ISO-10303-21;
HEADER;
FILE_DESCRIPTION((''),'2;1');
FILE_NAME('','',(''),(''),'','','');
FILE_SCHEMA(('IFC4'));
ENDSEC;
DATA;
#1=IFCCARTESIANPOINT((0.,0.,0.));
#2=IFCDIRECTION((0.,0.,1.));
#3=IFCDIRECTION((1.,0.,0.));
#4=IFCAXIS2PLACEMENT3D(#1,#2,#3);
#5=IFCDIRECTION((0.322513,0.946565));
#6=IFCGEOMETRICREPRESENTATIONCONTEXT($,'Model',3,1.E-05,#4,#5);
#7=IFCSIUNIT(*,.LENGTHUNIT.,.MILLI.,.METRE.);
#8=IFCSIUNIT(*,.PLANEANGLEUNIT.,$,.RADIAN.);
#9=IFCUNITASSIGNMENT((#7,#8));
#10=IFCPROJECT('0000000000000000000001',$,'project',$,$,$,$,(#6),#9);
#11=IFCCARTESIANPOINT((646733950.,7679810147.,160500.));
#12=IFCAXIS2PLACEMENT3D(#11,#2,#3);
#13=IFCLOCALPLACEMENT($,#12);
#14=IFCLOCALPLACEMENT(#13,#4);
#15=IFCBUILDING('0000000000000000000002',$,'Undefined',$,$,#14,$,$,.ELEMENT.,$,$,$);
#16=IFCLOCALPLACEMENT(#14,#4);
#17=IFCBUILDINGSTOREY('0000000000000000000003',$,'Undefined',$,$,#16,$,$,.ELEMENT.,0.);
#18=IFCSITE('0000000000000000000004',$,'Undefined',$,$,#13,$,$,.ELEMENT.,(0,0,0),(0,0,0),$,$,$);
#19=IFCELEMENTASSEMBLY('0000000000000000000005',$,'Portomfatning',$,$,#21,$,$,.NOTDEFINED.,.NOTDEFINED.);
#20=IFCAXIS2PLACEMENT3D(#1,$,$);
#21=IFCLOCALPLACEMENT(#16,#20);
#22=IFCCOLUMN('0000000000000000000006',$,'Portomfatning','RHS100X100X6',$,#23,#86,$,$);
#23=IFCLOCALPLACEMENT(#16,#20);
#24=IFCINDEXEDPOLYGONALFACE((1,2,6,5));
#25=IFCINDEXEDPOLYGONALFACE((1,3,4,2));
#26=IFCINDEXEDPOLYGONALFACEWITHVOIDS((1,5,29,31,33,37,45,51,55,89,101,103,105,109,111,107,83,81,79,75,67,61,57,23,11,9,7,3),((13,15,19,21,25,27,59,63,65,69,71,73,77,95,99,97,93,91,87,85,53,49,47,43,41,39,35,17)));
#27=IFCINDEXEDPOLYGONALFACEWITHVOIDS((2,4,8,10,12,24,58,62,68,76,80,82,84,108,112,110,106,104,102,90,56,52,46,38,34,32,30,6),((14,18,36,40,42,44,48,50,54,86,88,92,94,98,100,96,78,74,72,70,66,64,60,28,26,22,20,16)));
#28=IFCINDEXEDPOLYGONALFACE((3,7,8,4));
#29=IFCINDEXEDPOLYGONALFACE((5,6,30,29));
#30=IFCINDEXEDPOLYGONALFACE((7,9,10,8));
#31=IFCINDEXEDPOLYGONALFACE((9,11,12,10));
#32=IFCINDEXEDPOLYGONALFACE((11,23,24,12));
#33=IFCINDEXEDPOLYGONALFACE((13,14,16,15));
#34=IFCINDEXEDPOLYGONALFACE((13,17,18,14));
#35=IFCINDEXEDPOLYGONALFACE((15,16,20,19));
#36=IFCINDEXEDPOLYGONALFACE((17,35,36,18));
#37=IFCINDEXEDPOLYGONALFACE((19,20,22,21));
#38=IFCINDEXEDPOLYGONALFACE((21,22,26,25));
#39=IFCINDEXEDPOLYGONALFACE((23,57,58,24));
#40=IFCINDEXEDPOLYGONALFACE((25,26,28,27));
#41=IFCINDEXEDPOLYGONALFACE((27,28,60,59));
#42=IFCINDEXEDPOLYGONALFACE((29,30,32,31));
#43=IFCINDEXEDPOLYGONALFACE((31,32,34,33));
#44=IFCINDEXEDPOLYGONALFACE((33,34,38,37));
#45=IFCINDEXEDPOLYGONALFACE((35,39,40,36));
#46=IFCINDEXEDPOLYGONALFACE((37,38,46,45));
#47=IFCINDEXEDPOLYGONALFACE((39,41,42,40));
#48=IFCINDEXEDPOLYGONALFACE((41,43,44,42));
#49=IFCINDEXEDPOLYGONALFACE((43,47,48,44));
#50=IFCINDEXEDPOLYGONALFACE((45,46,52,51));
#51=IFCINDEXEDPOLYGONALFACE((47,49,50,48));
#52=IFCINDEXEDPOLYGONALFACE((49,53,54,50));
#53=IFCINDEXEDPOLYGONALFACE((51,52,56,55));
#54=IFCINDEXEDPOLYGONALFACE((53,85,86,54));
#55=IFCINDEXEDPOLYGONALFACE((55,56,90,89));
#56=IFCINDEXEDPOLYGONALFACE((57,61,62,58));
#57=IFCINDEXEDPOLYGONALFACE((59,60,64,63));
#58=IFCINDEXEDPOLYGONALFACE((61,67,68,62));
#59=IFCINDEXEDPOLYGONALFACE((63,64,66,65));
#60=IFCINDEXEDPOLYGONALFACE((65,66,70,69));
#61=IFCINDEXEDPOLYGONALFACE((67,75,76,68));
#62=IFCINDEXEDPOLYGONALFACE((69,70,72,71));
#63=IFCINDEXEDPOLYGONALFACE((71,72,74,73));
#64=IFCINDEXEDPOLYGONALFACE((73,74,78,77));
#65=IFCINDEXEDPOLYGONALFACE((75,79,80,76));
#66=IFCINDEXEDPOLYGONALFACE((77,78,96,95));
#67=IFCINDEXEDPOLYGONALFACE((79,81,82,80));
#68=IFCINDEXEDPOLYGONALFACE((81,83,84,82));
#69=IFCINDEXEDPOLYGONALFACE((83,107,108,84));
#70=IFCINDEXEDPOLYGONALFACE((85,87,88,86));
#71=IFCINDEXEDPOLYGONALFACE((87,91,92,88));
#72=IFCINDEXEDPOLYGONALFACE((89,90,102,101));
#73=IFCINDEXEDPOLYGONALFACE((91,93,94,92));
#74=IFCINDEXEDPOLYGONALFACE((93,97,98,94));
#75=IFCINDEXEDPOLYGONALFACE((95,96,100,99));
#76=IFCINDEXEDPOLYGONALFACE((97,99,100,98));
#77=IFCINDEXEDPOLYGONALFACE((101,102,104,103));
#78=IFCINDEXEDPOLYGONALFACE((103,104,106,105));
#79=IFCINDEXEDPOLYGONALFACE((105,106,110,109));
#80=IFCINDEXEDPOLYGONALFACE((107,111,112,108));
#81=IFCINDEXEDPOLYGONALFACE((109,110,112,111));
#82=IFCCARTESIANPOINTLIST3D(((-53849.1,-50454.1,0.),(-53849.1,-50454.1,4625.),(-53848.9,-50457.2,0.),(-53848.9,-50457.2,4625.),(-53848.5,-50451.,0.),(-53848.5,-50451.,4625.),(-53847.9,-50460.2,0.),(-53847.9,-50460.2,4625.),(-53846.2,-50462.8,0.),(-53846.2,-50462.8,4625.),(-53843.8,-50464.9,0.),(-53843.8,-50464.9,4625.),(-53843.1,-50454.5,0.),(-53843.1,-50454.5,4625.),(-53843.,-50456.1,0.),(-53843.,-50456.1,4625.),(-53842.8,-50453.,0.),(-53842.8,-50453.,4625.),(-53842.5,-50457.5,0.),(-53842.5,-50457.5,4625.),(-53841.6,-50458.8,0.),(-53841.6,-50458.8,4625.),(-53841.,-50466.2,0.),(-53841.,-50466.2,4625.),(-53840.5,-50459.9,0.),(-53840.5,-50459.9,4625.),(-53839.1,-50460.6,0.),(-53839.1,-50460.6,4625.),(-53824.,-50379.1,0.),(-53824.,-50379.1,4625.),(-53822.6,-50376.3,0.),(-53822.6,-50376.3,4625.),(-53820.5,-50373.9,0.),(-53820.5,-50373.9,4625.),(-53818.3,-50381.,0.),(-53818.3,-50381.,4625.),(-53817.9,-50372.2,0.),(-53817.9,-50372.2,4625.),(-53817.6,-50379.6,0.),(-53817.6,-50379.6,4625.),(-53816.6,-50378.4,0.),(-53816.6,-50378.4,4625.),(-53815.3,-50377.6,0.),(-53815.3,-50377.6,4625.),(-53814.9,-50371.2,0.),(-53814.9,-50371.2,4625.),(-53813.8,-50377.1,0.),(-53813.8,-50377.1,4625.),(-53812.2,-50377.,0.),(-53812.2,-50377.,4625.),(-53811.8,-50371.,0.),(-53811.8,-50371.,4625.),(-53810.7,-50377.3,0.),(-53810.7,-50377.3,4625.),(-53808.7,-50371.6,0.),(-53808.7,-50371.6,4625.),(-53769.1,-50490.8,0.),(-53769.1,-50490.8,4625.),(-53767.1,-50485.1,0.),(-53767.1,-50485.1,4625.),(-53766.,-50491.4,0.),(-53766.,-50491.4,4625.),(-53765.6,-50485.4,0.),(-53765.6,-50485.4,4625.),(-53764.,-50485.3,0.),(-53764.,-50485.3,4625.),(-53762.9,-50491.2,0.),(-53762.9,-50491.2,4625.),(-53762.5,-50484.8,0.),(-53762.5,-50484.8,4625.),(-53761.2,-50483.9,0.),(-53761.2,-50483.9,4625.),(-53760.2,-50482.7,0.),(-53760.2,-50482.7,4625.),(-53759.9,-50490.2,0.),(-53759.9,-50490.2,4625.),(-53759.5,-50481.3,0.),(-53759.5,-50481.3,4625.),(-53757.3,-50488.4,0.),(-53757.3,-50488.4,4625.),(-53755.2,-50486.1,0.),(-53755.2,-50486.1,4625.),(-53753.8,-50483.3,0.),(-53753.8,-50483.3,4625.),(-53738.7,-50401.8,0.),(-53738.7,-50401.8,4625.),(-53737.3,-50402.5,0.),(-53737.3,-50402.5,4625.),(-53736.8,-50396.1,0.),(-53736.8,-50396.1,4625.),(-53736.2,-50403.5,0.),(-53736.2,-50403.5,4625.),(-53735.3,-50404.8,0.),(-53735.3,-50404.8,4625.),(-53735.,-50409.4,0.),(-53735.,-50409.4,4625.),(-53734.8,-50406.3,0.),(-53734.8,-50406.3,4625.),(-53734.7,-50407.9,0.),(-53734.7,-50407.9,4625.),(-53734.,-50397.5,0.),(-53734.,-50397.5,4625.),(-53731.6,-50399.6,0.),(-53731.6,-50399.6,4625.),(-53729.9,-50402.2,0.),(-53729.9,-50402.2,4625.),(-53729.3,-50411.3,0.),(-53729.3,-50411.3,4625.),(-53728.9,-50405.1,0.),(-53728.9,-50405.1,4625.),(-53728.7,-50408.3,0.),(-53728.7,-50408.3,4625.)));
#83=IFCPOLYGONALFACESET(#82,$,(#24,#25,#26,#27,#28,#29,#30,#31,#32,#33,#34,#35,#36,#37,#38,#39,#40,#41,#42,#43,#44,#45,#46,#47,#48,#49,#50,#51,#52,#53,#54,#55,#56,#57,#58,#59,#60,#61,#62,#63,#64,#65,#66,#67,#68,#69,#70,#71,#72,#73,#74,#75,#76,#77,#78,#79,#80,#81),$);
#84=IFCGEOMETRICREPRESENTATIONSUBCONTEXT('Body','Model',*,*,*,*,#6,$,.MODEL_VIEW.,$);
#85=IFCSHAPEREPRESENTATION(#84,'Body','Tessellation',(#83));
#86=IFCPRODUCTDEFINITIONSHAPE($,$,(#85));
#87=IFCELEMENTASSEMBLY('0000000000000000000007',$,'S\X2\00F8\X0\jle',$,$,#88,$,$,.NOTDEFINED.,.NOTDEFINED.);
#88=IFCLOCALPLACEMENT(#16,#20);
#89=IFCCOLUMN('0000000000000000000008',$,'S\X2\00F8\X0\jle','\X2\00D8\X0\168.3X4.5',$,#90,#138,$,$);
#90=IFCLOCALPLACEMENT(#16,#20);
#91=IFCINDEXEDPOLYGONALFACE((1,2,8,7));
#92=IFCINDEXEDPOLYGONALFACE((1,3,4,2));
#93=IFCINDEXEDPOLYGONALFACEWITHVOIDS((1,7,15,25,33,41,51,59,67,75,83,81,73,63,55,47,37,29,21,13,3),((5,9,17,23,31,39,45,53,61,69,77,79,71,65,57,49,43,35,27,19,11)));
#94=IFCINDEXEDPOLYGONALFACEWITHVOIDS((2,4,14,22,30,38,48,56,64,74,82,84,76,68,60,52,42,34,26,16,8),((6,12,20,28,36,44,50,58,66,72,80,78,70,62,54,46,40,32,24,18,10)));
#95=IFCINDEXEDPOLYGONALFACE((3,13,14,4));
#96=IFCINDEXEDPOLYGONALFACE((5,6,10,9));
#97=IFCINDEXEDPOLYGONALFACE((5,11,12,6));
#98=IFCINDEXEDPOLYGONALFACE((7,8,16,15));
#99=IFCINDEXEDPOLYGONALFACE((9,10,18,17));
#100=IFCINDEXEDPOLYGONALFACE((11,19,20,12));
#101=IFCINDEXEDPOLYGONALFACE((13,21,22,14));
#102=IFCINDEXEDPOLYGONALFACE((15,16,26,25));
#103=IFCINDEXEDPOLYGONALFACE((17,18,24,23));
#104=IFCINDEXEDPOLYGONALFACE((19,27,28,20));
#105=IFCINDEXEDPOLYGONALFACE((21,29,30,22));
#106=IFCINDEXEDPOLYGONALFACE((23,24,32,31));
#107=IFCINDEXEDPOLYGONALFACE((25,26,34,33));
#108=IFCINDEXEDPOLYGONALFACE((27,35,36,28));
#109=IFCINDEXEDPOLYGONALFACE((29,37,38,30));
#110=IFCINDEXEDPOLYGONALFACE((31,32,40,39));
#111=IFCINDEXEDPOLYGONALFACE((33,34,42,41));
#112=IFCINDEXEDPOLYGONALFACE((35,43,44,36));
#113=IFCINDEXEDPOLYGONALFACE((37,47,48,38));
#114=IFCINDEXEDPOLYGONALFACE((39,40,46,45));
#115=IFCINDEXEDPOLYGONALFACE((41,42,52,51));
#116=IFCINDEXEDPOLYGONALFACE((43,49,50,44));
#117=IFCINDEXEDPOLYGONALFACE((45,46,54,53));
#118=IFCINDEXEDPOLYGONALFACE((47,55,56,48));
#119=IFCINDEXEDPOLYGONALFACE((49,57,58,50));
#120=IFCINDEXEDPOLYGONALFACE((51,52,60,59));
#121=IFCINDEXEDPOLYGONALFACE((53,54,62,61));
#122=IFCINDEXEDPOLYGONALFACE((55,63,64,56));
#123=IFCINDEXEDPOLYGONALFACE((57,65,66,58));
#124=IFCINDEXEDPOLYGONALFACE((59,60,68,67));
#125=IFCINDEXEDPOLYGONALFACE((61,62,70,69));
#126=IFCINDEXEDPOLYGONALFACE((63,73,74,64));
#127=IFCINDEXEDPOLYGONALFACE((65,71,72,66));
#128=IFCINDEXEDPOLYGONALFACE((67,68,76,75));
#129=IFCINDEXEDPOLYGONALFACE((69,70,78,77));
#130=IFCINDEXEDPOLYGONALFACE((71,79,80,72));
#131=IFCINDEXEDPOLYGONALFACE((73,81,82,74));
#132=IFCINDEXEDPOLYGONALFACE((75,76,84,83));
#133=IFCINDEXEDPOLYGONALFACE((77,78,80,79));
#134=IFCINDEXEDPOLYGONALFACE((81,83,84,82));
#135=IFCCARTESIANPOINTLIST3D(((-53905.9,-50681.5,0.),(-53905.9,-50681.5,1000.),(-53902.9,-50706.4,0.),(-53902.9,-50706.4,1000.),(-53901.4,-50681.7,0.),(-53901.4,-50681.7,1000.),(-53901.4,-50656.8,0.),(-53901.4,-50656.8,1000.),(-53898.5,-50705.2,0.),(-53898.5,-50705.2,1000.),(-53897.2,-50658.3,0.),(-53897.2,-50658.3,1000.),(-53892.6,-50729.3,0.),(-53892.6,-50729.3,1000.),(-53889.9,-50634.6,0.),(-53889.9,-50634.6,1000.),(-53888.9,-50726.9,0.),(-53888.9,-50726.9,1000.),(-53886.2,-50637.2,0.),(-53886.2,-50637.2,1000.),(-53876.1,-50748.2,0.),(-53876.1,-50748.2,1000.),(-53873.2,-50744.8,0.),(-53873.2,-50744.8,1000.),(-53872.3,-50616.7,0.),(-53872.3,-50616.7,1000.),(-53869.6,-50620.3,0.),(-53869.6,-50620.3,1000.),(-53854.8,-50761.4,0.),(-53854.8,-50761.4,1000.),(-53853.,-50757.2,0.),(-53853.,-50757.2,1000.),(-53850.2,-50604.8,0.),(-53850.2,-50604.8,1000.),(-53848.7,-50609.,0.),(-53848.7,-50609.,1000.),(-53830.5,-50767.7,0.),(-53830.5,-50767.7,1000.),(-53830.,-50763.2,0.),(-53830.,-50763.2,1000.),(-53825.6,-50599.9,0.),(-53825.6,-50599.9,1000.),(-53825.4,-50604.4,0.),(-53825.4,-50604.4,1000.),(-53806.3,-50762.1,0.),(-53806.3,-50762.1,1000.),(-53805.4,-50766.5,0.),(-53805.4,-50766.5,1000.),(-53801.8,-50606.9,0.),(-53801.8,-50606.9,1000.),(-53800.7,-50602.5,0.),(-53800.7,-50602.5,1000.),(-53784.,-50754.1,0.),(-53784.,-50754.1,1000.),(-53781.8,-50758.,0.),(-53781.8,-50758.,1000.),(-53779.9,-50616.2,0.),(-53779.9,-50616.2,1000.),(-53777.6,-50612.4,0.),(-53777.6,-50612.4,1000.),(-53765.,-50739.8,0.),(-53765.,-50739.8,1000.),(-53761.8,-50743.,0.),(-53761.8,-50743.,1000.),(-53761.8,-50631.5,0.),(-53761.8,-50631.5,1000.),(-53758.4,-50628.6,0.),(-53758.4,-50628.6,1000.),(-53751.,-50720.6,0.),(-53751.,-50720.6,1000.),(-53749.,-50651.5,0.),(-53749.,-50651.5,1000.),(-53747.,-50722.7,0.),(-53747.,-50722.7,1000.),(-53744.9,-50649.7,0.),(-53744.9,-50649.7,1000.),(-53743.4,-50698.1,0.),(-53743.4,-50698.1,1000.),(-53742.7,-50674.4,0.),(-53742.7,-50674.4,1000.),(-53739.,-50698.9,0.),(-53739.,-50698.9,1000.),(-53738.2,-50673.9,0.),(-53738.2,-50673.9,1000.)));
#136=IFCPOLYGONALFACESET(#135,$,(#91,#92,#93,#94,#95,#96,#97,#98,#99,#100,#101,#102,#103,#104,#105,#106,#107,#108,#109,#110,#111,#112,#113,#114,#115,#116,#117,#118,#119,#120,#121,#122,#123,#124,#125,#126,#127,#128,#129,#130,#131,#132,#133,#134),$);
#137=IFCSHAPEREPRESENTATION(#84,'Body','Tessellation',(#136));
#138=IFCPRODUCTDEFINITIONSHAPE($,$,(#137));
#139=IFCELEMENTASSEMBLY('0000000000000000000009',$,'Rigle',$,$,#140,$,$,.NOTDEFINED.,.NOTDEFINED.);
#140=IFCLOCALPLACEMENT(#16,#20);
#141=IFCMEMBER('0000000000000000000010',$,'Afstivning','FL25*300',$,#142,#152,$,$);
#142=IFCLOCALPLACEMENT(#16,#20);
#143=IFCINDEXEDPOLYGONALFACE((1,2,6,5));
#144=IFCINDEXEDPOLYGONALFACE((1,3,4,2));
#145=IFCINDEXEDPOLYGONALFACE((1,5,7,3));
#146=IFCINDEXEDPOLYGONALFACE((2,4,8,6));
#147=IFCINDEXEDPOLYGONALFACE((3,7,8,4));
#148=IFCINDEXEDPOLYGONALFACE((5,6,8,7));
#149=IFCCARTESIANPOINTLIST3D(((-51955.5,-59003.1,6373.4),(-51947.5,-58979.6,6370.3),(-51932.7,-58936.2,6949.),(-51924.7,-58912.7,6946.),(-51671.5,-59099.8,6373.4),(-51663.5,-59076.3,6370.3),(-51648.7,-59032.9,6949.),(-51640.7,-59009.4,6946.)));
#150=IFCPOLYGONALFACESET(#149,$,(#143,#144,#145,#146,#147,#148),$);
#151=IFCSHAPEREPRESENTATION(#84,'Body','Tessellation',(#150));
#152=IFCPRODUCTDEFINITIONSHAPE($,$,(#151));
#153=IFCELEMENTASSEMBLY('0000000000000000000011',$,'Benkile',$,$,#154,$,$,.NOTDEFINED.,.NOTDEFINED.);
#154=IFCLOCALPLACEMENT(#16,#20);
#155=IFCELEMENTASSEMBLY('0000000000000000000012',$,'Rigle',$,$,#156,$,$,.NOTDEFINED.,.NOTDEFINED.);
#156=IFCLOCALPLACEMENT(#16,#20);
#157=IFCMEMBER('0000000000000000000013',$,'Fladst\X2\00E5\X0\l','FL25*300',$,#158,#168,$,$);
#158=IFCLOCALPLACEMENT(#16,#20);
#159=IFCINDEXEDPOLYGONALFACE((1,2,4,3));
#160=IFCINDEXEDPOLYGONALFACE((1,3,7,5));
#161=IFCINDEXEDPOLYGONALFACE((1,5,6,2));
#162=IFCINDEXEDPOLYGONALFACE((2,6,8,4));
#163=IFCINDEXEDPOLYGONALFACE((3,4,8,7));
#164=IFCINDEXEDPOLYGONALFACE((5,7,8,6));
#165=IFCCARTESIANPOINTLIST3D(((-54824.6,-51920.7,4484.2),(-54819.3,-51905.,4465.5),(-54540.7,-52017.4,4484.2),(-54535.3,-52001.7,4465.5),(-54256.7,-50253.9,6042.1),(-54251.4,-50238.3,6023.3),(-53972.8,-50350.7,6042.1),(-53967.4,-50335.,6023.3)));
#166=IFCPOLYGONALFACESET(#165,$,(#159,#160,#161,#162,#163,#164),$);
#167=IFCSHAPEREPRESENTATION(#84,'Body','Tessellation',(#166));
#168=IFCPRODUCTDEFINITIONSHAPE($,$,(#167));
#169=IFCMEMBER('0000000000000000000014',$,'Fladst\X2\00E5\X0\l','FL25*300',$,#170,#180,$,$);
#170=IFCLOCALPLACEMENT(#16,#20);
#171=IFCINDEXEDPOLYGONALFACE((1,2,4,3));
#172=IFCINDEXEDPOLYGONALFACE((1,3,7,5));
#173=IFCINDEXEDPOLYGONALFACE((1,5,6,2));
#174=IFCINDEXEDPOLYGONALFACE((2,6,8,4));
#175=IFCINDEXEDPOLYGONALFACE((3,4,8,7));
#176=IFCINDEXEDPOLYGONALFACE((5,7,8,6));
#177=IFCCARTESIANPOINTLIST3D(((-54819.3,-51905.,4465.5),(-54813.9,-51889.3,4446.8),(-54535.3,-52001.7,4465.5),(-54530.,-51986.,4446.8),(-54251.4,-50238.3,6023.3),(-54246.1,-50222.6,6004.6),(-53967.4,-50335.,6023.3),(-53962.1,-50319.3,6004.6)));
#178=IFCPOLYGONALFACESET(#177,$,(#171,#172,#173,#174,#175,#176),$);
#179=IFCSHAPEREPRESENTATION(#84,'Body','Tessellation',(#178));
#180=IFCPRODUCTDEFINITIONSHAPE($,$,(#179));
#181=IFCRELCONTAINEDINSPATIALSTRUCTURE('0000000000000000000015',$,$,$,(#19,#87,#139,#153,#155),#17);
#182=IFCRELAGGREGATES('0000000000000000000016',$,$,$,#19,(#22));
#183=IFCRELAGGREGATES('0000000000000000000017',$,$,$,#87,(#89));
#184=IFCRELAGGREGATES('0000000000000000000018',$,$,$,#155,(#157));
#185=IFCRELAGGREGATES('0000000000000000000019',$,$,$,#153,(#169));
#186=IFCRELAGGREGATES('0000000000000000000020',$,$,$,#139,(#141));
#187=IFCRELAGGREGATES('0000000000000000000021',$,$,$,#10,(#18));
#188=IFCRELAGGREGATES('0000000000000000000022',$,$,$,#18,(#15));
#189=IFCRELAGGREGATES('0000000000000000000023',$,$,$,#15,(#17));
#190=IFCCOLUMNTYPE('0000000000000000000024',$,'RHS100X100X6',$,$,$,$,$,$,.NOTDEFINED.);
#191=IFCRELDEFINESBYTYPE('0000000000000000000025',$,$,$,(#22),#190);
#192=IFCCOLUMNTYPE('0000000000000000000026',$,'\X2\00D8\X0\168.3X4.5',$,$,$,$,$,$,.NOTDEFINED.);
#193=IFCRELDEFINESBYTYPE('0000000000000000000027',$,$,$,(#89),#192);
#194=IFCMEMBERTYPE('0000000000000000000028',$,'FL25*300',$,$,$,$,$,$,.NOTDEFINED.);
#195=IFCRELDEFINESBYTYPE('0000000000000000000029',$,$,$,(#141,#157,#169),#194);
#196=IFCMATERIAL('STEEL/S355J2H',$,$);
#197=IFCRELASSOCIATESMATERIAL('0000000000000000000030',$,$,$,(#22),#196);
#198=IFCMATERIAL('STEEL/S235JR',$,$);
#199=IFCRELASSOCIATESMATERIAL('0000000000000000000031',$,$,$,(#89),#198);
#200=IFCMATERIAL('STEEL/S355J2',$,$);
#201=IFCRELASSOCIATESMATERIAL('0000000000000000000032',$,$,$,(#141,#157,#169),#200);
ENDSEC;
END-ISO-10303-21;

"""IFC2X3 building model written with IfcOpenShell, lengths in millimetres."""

from ifc_helpers import new_model, si_unit, direction, frame, origin_with_axes, origin_2d_with_axis, place, context, subcontext, project, spatial, rectangle, hollow_rectangle, hollow_circle, extrude, material, type_object, element, aggregate, save


model = new_model("IFC2X3")

# Units and contexts
model_context = context("Model", 3, precision=1e-05, world=origin_with_axes(), true_north=direction((0.322513, 0.946565)))
body_context = subcontext(model_context, "Body", "Model", "MODEL_VIEW")
ifc_project = project(units=[si_unit("LENGTHUNIT", "METRE", prefix="MILLI"), si_unit("PLANEANGLEUNIT", "RADIAN")], contexts=[model_context])

# Site, building, storey
site_placement = place(None, frame((646733950.0, 7679810147.0, 160500.0), z_axis=(0.0, 0.0, 1.0), x_axis=(1.0, 0.0, 0.0)))
site = spatial("IfcSite", under=ifc_project, at=site_placement, Name="Undefined", CompositionType="ELEMENT", RefLatitude=(0, 0, 0), RefLongitude=(0, 0, 0))
building_placement = place(site_placement, origin_with_axes())
building = spatial("IfcBuilding", under=site, at=building_placement, Name="Undefined", CompositionType="ELEMENT")
storey_placement = place(building_placement, origin_with_axes())
storey = spatial("IfcBuildingStorey", under=building, at=storey_placement, Name="Undefined", CompositionType="ELEMENT", Elevation=0.0)

# Element assemblies, columns
assembly_1_placement = place(storey_placement, origin_with_axes())
assembly_1 = element("IfcElementAssembly", 1, at=assembly_1_placement, inside=storey, Name="Portomfatning", AssemblyPlace="NOTDEFINED", PredefinedType="NOTDEFINED")
ifc_material_1 = material(Name="STEEL/S355J2H")
column_type_1 = type_object("IfcColumnType", Name="RHS100X100X6", PredefinedType="NOTDEFINED")
column_1_placement = place(assembly_1_placement, frame((-53788.9, -50431.2, 0.0), z_axis=(0.0, 0.0, 1.0), x_axis=(-0.946565, 0.322513, 0.0)))
column_1 = element("IfcColumn", 2, at=column_1_placement, type_object=column_type_1, material=ifc_material_1, Name="Portomfatning", Description="RHS100X100X6", context=body_context, shape_type="SweptSolid", body=[
    extrude(hollow_rectangle(XDim=100.0, YDim=100.0, WallThickness=6.0, InnerFilletRadius=6.0, OuterFilletRadius=12.0, at=origin_2d_with_axis()), frame((0.0, 0.0, 4625.0), z_axis=(0.0, 0.0, -1.0), x_axis=(0.0, 1.0, 0.0)), (0.0, 0.0, 1.0), 4625.0),
])
aggregate(assembly_1, [column_1])
assembly_2_placement = place(storey_placement, origin_with_axes())
assembly_2 = element("IfcElementAssembly", 3, at=assembly_2_placement, inside=storey, Name="Søjle", AssemblyPlace="NOTDEFINED", PredefinedType="NOTDEFINED")
ifc_material_2 = material(Name="STEEL/S235JR")
column_type_2 = type_object("IfcColumnType", Name="Ø168.3X4.5", PredefinedType="NOTDEFINED")
column_2_placement = place(assembly_2_placement, frame((-53821.8, -50684.0, 0.0), z_axis=(0.0, 0.0, 1.0), x_axis=(0.322513, 0.946565, 0.0)))
column_2 = element("IfcColumn", 4, at=column_2_placement, type_object=column_type_2, material=ifc_material_2, Name="Søjle", Description="Ø168.3X4.5", context=body_context, shape_type="SweptSolid", body=[
    extrude(hollow_circle(Radius=84.2, WallThickness=4.5, at=origin_2d_with_axis()), frame((0.0, 0.0, 1000.0), z_axis=(0.0, 0.0, -1.0), x_axis=(0.0, 1.0, 0.0)), (0.0, 0.0, 1.0), 1000.0),
])
aggregate(assembly_2, [column_2])

# Element assemblies, members
assembly_3_placement = place(storey_placement, origin_with_axes())
assembly_3 = element("IfcElementAssembly", 5, at=assembly_3_placement, inside=storey, Name="Rigle", AssemblyPlace="NOTDEFINED", PredefinedType="NOTDEFINED")
ifc_material_3 = material(Name="STEEL/S355J2")
member_type = type_object("IfcMemberType", Name="FL25*300", PredefinedType="NOTDEFINED")
member_1_placement = place(assembly_3_placement, frame((-51786.7, -58972.8, 6947.5), z_axis=(-0.946565, 0.322513, 0.0), x_axis=(-0.039304, -0.115357, -0.992546)))
member_1 = element("IfcMember", 6, at=member_1_placement, type_object=member_type, material=ifc_material_3, Name="Afstivning", Description="FL25*300", context=body_context, shape_type="SweptSolid", body=[
    extrude(rectangle(XDim=25.0, YDim=300.0, at=origin_2d_with_axis()), frame((580.0, 0.0, 0.0), z_axis=(-1.0, 0.0, 0.0), x_axis=(0.0, -1.0, 0.0)), (0.0, 0.0, 1.0), 580.0),
])
assembly_4_placement = place(storey_placement, origin_with_axes())
assembly_4 = element("IfcElementAssembly", 7, at=assembly_4_placement, inside=storey, Name="Benkile", AssemblyPlace="NOTDEFINED", PredefinedType="NOTDEFINED")
assembly_5_placement = place(storey_placement, origin_with_axes())
assembly_5 = element("IfcElementAssembly", 8, at=assembly_5_placement, inside=storey, Name="Rigle", AssemblyPlace="NOTDEFINED", PredefinedType="NOTDEFINED")
member_2_placement = place(assembly_5_placement, frame((-54112.1, -50294.5, 6032.7), z_axis=(-0.946565, 0.322513, 0.0), x_axis=(-0.241548, -0.708935, -0.66262)))
member_2 = element("IfcMember", 9, at=member_2_placement, type_object=member_type, material=ifc_material_3, Name="Fladstål", Description="FL25*300", context=body_context, shape_type="SweptSolid", body=[
    extrude(rectangle(XDim=25.0, YDim=300.0, at=origin_2d_with_axis()), frame((2351.0, 0.0, 0.0), z_axis=(-1.0, 0.0, 0.0), x_axis=(0.0, -1.0, 0.0)), (0.0, 0.0, 1.0), 2351.0),
])

# Member
member_3_placement = place(assembly_4_placement, frame((-54106.7, -50278.8, 6014.0), z_axis=(-0.946565, 0.322513, 0.0), x_axis=(-0.241548, -0.708935, -0.66262)))
member_3 = element("IfcMember", 10, at=member_3_placement, type_object=member_type, material=ifc_material_3, Name="Fladstål", Description="FL25*300", context=body_context, shape_type="SweptSolid", body=[
    extrude(rectangle(XDim=25.0, YDim=300.0, at=origin_2d_with_axis()), frame((2351.0, 0.0, 0.0), z_axis=(-1.0, 0.0, 0.0), x_axis=(0.0, -1.0, 0.0)), (0.0, 0.0, 1.0), 2351.0),
])

aggregate(assembly_5, [member_2])

aggregate(assembly_4, [member_3])
aggregate(assembly_3, [member_1])

save(model, "model.ifc")
